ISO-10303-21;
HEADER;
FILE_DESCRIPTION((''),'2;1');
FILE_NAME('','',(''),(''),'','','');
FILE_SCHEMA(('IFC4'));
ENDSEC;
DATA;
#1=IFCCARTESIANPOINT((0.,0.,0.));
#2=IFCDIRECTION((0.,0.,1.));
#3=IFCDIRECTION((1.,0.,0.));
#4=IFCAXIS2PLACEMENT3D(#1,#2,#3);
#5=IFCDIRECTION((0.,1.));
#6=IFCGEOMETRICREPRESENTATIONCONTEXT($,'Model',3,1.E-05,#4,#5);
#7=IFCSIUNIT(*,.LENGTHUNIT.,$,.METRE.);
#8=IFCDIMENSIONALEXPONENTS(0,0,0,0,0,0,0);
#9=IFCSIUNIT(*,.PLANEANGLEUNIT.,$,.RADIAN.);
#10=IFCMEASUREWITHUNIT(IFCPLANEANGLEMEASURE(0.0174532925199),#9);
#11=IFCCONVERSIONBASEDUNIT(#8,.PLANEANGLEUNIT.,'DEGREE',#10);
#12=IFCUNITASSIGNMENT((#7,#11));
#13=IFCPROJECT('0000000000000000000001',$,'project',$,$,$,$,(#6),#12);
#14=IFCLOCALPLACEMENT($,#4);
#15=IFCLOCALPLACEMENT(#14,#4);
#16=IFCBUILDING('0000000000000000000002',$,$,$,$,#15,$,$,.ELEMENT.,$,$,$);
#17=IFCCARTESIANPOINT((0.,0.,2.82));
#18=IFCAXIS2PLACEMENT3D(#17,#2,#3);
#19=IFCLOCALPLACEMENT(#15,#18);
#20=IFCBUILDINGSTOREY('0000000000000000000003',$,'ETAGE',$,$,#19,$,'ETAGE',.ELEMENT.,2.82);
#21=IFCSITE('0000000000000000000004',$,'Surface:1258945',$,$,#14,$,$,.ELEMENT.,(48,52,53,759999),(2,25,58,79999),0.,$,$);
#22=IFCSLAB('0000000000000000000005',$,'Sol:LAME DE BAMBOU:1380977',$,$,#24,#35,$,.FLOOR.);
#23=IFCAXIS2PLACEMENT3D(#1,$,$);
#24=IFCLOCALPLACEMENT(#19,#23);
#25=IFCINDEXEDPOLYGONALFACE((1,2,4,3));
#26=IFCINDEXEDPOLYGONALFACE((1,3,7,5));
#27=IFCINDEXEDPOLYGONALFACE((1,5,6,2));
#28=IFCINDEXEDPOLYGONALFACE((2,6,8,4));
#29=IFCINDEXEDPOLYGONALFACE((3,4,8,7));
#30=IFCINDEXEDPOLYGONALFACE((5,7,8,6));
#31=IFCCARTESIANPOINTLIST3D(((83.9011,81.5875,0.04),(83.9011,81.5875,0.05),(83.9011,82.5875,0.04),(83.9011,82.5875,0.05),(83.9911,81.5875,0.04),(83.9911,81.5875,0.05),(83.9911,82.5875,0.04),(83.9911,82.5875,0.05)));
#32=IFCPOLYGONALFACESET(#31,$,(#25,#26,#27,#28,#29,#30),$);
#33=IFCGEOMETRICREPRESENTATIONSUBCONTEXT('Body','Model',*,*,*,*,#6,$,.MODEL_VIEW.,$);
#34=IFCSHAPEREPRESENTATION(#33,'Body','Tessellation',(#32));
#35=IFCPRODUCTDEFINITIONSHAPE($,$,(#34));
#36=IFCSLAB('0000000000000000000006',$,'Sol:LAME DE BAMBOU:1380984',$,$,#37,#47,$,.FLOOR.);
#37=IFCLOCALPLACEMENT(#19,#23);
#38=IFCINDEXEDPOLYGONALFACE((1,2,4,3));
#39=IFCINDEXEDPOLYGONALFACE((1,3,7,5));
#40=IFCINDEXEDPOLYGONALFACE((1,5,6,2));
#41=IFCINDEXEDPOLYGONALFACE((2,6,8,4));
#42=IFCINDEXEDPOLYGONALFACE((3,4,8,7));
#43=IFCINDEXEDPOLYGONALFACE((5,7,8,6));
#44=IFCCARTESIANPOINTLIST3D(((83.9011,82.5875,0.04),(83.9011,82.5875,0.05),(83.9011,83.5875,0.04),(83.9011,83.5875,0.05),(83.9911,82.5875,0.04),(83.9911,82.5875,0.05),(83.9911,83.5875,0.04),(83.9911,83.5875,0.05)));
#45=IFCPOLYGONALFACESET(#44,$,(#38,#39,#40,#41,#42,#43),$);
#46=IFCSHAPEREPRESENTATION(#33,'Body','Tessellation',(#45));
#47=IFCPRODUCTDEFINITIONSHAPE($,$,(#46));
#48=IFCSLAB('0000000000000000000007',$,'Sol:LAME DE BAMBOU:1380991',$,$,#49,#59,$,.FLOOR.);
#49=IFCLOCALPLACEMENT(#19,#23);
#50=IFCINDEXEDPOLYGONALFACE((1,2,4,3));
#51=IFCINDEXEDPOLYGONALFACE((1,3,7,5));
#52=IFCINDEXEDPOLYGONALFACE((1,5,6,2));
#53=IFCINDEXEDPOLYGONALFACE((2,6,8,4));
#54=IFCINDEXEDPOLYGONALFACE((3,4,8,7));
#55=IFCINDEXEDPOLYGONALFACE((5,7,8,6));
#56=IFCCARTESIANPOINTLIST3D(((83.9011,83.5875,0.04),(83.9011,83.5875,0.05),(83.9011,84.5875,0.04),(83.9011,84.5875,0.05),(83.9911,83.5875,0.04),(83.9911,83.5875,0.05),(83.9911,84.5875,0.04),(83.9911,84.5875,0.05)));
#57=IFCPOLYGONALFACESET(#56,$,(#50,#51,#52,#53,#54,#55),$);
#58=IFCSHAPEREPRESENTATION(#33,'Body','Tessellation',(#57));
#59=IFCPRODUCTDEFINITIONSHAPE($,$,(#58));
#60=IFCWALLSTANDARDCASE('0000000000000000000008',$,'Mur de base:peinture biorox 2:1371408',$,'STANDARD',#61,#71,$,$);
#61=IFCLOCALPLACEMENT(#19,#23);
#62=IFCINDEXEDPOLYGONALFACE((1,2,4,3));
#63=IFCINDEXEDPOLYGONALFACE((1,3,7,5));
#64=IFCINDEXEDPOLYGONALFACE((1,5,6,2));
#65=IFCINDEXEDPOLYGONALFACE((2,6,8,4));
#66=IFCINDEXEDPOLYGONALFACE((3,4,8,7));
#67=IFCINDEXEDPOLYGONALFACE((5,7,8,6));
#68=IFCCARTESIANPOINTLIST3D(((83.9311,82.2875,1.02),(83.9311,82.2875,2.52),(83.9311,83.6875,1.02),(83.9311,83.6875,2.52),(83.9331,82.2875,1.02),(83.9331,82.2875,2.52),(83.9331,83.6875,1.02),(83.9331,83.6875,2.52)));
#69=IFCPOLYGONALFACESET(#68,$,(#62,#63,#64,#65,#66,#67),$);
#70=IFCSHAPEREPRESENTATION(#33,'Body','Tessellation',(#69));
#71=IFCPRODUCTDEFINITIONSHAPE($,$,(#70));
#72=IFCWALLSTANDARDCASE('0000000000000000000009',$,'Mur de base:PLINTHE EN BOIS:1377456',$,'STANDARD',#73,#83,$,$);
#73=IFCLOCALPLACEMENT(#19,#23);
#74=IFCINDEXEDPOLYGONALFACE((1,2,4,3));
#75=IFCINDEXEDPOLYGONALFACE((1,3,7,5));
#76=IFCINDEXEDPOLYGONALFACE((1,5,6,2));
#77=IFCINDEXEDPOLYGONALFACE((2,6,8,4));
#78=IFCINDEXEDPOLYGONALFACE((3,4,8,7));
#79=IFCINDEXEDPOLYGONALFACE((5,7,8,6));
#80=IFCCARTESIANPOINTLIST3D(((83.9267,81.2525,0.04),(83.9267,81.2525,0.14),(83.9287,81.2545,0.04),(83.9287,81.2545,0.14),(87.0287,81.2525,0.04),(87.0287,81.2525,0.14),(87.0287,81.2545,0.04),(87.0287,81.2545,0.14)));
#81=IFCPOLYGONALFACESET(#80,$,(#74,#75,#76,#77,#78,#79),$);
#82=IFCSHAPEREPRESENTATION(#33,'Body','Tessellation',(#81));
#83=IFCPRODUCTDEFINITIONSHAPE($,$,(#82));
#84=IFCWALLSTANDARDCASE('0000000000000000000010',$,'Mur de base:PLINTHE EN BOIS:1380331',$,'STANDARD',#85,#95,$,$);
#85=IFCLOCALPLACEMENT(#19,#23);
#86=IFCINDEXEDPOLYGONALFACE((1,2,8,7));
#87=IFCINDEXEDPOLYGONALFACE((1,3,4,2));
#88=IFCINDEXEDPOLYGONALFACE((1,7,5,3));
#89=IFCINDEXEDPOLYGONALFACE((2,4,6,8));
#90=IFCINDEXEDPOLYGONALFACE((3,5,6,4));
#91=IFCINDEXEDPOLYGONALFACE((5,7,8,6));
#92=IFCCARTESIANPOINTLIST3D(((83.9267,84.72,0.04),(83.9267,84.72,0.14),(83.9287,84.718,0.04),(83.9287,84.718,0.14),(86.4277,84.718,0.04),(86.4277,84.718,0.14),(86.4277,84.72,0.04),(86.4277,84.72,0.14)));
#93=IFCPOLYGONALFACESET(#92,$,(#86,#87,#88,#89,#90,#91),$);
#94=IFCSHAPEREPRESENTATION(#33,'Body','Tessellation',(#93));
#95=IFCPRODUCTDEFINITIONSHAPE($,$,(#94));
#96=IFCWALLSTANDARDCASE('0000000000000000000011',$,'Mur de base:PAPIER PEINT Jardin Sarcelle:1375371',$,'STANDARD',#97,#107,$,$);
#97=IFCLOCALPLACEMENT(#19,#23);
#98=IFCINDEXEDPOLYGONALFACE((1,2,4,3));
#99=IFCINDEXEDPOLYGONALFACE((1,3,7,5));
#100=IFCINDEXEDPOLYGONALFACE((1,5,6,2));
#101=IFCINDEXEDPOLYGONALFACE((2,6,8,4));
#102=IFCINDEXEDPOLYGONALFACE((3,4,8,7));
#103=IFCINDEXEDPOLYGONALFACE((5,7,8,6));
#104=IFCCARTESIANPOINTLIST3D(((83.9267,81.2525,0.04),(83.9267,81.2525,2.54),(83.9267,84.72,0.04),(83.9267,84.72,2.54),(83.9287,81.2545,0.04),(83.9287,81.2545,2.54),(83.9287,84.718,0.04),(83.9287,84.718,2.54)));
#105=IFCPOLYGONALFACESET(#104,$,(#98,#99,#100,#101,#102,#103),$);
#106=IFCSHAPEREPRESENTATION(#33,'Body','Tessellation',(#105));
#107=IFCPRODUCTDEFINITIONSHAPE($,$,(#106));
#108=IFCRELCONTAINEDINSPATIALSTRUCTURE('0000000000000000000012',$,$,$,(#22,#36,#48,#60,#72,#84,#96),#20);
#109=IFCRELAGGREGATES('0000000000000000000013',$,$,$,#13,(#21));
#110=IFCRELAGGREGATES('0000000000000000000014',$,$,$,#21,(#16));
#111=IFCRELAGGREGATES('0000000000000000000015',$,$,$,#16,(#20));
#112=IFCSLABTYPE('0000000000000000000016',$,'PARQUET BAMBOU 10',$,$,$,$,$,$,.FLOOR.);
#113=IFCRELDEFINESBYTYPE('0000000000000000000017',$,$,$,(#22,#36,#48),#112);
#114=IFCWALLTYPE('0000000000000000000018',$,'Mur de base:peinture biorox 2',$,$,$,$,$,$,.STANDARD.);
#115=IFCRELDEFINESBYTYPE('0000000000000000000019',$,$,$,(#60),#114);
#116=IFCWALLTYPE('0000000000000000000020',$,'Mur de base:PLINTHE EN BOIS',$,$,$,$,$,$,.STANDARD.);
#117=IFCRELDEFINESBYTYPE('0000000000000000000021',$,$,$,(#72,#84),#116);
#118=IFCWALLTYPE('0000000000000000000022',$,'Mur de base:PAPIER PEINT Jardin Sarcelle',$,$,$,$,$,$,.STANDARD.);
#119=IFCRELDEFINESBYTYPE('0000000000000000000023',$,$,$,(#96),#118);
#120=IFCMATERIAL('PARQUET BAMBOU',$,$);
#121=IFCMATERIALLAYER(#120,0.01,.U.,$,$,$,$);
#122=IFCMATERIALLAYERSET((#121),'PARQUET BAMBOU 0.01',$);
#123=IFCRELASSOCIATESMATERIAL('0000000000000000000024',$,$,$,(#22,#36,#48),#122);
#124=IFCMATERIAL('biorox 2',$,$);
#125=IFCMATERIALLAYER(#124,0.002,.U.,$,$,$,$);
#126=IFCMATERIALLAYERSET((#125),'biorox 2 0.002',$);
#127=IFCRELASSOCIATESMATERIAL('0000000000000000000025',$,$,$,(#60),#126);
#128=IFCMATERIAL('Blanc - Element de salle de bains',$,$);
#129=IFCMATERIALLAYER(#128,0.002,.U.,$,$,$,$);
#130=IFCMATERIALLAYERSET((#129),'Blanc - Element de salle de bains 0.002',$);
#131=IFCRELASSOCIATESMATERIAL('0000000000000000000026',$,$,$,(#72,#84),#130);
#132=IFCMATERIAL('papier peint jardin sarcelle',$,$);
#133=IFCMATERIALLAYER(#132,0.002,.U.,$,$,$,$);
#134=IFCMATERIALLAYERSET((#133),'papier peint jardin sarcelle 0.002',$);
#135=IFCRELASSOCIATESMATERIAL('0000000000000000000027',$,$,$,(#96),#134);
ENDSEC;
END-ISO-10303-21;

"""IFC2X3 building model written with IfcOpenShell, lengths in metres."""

from ifc_helpers import new_model, entity, si_unit, converted_unit, direction, frame, origin_with_axes, place, context, subcontext, project, spatial, polyline, outline, extrude, clip, halfspace, material, layer, layer_set, layer_usage, type_object, element, save


model = new_model("IFC2X3")

# Units and contexts
model_context = context("Model", 3, precision=1e-05, world=origin_with_axes(), true_north=direction((0.0, 1.0)))
body_context = subcontext(model_context, "Body", "Model", "MODEL_VIEW")
ifc_project = project(units=[si_unit("LENGTHUNIT", "METRE"), converted_unit("PLANEANGLEUNIT", "DEGREE", entity("IfcPlaneAngleMeasure", 0.0174532925199), si_unit("PLANEANGLEUNIT", "RADIAN"), dimensions=[0, 0, 0, 0, 0, 0, 0])], contexts=[model_context])

# Site, building, storey
site_placement = place(None, origin_with_axes())
site = spatial("IfcSite", under=ifc_project, at=site_placement, Name="Surface:1258945", CompositionType="ELEMENT", RefLatitude=(48, 52, 53, 759999), RefLongitude=(2, 25, 58, 79999), RefElevation=0.0)
building_placement = place(site_placement, origin_with_axes())
building = spatial("IfcBuilding", under=site, at=building_placement, CompositionType="ELEMENT")
storey_placement = place(building_placement, frame((0.0, 0.0, 2.82), z_axis=(0.0, 0.0, 1.0), x_axis=(1.0, 0.0, 0.0)))
storey = spatial("IfcBuildingStorey", under=building, at=storey_placement, Name="ETAGE", LongName="ETAGE", CompositionType="ELEMENT", Elevation=2.82)

# Slabs
ifc_material_1 = material(Name="PARQUET BAMBOU")
ifc_layer_1 = layer(ifc_material_1, 0.01, ventilated="UNKNOWN")
ifc_layer_set_1 = layer_set([ifc_layer_1], Name="PARQUET BAMBOU 0.01")
slab_type = type_object("IfcSlabType", Name="PARQUET BAMBOU 10", PredefinedType="FLOOR")
ifc_layer_usage_1 = layer_usage(ifc_layer_set_1, "AXIS3", "NEGATIVE", 0.01)
slab_1_placement = place(storey_placement, frame((83.9011, 82.5875, 0.05), z_axis=(0.0, 0.0, 1.0), x_axis=(1.0, 0.0, 0.0)))
element("IfcSlab", 1, at=slab_1_placement, inside=storey, type_object=slab_type, material=ifc_layer_usage_1, Name="Sol:LAME DE BAMBOU:1380977", PredefinedType="FLOOR", context=body_context, shape_type="SweptSolid", body=[
    extrude(outline(polyline([(0.0, 0.0), (0.0, -1.0), (0.09, -1.0), (0.09, 0.0), (0.0, 0.0)])), frame((0.0, 0.0, -0.01), z_axis=(0.0, 0.0, 1.0), x_axis=(1.0, 0.0, 0.0)), (0.0, 0.0, 1.0), 0.01),
])
ifc_layer_usage_2 = layer_usage(ifc_layer_set_1, "AXIS3", "NEGATIVE", 0.01)
slab_2_placement = place(storey_placement, frame((83.9011, 83.5875, 0.05), z_axis=(0.0, 0.0, 1.0), x_axis=(1.0, 0.0, 0.0)))
element("IfcSlab", 2, at=slab_2_placement, inside=storey, type_object=slab_type, material=ifc_layer_usage_2, Name="Sol:LAME DE BAMBOU:1380984", PredefinedType="FLOOR", context=body_context, shape_type="SweptSolid", body=[
    extrude(outline(polyline([(0.0, 0.0), (0.0, -1.0), (0.09, -1.0), (0.09, 0.0), (0.0, 0.0)])), frame((0.0, 0.0, -0.01), z_axis=(0.0, 0.0, 1.0), x_axis=(1.0, 0.0, 0.0)), (0.0, 0.0, 1.0), 0.01),
])
ifc_layer_usage_3 = layer_usage(ifc_layer_set_1, "AXIS3", "NEGATIVE", 0.01)
slab_3_placement = place(storey_placement, frame((83.9011, 84.5875, 0.05), z_axis=(0.0, 0.0, 1.0), x_axis=(1.0, 0.0, 0.0)))
element("IfcSlab", 3, at=slab_3_placement, inside=storey, type_object=slab_type, material=ifc_layer_usage_3, Name="Sol:LAME DE BAMBOU:1380991", PredefinedType="FLOOR", context=body_context, shape_type="SweptSolid", body=[
    extrude(outline(polyline([(0.0, 0.0), (0.0, -1.0), (0.09, -1.0), (0.09, 0.0), (0.0, 0.0)])), frame((0.0, 0.0, -0.01), z_axis=(0.0, 0.0, 1.0), x_axis=(1.0, 0.0, 0.0)), (0.0, 0.0, 1.0), 0.01),
])

# Walls
ifc_material_2 = material(Name="biorox 2")
ifc_layer_2 = layer(ifc_material_2, 0.002, ventilated="UNKNOWN")
ifc_layer_set_2 = layer_set([ifc_layer_2], Name="biorox 2 0.002")
ifc_layer_usage_4 = layer_usage(ifc_layer_set_2, "AXIS2", "POSITIVE", -0.001)
wall_type_1 = type_object("IfcWallType", Name="Mur de base:peinture biorox 2", PredefinedType="STANDARD")
wall_1_placement = place(storey_placement, frame((83.9321, 83.6875, 1.02), z_axis=(0.0, 0.0, 1.0), x_axis=(0.0, -1.0, 0.0)))
element("IfcWallStandardCase", 4, at=wall_1_placement, inside=storey, type_object=wall_type_1, material=ifc_layer_usage_4, Name="Mur de base:peinture biorox 2:1371408", ObjectType="STANDARD", context=body_context, shape_type="Clipping", body=[
    clip(clip(extrude(outline(polyline([(0.0, -0.001), (1.4, -0.001), (1.4, 0.001), (0.0, 0.001), (0.0, -0.001)])), origin_with_axes(), (0.0, 0.0, 1.0), 1.5), halfspace(frame((0.0, 0.0, 1.5), z_axis=(0.0, 0.0, -1.0), x_axis=(0.0, 1.0, 0.0)), True)), halfspace(frame((0.0, 0.0, 0.0), z_axis=(0.0, 0.0, 1.0), x_axis=(0.0, -1.0, 0.0)), True)),
])
ifc_material_3 = material(Name="Blanc - Element de salle de bains")
ifc_layer_3 = layer(ifc_material_3, 0.002, ventilated="UNKNOWN")
ifc_layer_set_3 = layer_set([ifc_layer_3], Name="Blanc - Element de salle de bains 0.002")
ifc_layer_usage_5 = layer_usage(ifc_layer_set_3, "AXIS2", "POSITIVE", -0.001)
wall_type_2 = type_object("IfcWallType", Name="Mur de base:PLINTHE EN BOIS", PredefinedType="STANDARD")
wall_2_placement = place(storey_placement, frame((83.9277, 81.2535, 0.04), z_axis=(0.0, 0.0, 1.0), x_axis=(1.0, 0.0, 0.0)))
element("IfcWallStandardCase", 5, at=wall_2_placement, inside=storey, type_object=wall_type_2, material=ifc_layer_usage_5, Name="Mur de base:PLINTHE EN BOIS:1377456", ObjectType="STANDARD", context=body_context, shape_type="SweptSolid", body=[
    extrude(outline(polyline([(-0.001, -0.001), (3.101, -0.001), (3.101, 0.001), (0.001, 0.001), (-0.001, -0.001)])), origin_with_axes(), (0.0, 0.0, 1.0), 0.1),
])
ifc_layer_usage_6 = layer_usage(ifc_layer_set_3, "AXIS2", "POSITIVE", -0.001)
wall_3_placement = place(storey_placement, frame((83.9277, 84.719, 0.04), z_axis=(0.0, 0.0, 1.0), x_axis=(1.0, 0.0, 0.0)))
element("IfcWallStandardCase", 6, at=wall_3_placement, inside=storey, type_object=wall_type_2, material=ifc_layer_usage_6, Name="Mur de base:PLINTHE EN BOIS:1380331", ObjectType="STANDARD", context=body_context, shape_type="SweptSolid", body=[
    extrude(outline(polyline([(0.001, -0.001), (2.5, -0.001), (2.5, 0.001), (-0.001, 0.001), (0.001, -0.001)])), origin_with_axes(), (0.0, 0.0, 1.0), 0.1),
])
ifc_material_4 = material(Name="papier peint jardin sarcelle")
ifc_layer_4 = layer(ifc_material_4, 0.002, ventilated="UNKNOWN")
ifc_layer_set_4 = layer_set([ifc_layer_4], Name="papier peint jardin sarcelle 0.002")
ifc_layer_usage_7 = layer_usage(ifc_layer_set_4, "AXIS2", "POSITIVE", -0.001)
wall_type_3 = type_object("IfcWallType", Name="Mur de base:PAPIER PEINT Jardin Sarcelle", PredefinedType="STANDARD")
wall_4_placement = place(storey_placement, frame((83.9277, 84.719, 0.04), z_axis=(0.0, 0.0, 1.0), x_axis=(0.0, -1.0, 0.0)))
element("IfcWallStandardCase", 7, at=wall_4_placement, inside=storey, type_object=wall_type_3, material=ifc_layer_usage_7, Name="Mur de base:PAPIER PEINT Jardin Sarcelle:1375371", ObjectType="STANDARD", context=body_context, shape_type="SweptSolid", body=[
    extrude(outline(polyline([(-0.001, -0.001), (3.4665, -0.001), (3.4645, 0.001), (0.001, 0.001), (-0.001, -0.001)])), origin_with_axes(), (0.0, 0.0, 1.0), 2.5),
])

save(model, "model.ifc")
